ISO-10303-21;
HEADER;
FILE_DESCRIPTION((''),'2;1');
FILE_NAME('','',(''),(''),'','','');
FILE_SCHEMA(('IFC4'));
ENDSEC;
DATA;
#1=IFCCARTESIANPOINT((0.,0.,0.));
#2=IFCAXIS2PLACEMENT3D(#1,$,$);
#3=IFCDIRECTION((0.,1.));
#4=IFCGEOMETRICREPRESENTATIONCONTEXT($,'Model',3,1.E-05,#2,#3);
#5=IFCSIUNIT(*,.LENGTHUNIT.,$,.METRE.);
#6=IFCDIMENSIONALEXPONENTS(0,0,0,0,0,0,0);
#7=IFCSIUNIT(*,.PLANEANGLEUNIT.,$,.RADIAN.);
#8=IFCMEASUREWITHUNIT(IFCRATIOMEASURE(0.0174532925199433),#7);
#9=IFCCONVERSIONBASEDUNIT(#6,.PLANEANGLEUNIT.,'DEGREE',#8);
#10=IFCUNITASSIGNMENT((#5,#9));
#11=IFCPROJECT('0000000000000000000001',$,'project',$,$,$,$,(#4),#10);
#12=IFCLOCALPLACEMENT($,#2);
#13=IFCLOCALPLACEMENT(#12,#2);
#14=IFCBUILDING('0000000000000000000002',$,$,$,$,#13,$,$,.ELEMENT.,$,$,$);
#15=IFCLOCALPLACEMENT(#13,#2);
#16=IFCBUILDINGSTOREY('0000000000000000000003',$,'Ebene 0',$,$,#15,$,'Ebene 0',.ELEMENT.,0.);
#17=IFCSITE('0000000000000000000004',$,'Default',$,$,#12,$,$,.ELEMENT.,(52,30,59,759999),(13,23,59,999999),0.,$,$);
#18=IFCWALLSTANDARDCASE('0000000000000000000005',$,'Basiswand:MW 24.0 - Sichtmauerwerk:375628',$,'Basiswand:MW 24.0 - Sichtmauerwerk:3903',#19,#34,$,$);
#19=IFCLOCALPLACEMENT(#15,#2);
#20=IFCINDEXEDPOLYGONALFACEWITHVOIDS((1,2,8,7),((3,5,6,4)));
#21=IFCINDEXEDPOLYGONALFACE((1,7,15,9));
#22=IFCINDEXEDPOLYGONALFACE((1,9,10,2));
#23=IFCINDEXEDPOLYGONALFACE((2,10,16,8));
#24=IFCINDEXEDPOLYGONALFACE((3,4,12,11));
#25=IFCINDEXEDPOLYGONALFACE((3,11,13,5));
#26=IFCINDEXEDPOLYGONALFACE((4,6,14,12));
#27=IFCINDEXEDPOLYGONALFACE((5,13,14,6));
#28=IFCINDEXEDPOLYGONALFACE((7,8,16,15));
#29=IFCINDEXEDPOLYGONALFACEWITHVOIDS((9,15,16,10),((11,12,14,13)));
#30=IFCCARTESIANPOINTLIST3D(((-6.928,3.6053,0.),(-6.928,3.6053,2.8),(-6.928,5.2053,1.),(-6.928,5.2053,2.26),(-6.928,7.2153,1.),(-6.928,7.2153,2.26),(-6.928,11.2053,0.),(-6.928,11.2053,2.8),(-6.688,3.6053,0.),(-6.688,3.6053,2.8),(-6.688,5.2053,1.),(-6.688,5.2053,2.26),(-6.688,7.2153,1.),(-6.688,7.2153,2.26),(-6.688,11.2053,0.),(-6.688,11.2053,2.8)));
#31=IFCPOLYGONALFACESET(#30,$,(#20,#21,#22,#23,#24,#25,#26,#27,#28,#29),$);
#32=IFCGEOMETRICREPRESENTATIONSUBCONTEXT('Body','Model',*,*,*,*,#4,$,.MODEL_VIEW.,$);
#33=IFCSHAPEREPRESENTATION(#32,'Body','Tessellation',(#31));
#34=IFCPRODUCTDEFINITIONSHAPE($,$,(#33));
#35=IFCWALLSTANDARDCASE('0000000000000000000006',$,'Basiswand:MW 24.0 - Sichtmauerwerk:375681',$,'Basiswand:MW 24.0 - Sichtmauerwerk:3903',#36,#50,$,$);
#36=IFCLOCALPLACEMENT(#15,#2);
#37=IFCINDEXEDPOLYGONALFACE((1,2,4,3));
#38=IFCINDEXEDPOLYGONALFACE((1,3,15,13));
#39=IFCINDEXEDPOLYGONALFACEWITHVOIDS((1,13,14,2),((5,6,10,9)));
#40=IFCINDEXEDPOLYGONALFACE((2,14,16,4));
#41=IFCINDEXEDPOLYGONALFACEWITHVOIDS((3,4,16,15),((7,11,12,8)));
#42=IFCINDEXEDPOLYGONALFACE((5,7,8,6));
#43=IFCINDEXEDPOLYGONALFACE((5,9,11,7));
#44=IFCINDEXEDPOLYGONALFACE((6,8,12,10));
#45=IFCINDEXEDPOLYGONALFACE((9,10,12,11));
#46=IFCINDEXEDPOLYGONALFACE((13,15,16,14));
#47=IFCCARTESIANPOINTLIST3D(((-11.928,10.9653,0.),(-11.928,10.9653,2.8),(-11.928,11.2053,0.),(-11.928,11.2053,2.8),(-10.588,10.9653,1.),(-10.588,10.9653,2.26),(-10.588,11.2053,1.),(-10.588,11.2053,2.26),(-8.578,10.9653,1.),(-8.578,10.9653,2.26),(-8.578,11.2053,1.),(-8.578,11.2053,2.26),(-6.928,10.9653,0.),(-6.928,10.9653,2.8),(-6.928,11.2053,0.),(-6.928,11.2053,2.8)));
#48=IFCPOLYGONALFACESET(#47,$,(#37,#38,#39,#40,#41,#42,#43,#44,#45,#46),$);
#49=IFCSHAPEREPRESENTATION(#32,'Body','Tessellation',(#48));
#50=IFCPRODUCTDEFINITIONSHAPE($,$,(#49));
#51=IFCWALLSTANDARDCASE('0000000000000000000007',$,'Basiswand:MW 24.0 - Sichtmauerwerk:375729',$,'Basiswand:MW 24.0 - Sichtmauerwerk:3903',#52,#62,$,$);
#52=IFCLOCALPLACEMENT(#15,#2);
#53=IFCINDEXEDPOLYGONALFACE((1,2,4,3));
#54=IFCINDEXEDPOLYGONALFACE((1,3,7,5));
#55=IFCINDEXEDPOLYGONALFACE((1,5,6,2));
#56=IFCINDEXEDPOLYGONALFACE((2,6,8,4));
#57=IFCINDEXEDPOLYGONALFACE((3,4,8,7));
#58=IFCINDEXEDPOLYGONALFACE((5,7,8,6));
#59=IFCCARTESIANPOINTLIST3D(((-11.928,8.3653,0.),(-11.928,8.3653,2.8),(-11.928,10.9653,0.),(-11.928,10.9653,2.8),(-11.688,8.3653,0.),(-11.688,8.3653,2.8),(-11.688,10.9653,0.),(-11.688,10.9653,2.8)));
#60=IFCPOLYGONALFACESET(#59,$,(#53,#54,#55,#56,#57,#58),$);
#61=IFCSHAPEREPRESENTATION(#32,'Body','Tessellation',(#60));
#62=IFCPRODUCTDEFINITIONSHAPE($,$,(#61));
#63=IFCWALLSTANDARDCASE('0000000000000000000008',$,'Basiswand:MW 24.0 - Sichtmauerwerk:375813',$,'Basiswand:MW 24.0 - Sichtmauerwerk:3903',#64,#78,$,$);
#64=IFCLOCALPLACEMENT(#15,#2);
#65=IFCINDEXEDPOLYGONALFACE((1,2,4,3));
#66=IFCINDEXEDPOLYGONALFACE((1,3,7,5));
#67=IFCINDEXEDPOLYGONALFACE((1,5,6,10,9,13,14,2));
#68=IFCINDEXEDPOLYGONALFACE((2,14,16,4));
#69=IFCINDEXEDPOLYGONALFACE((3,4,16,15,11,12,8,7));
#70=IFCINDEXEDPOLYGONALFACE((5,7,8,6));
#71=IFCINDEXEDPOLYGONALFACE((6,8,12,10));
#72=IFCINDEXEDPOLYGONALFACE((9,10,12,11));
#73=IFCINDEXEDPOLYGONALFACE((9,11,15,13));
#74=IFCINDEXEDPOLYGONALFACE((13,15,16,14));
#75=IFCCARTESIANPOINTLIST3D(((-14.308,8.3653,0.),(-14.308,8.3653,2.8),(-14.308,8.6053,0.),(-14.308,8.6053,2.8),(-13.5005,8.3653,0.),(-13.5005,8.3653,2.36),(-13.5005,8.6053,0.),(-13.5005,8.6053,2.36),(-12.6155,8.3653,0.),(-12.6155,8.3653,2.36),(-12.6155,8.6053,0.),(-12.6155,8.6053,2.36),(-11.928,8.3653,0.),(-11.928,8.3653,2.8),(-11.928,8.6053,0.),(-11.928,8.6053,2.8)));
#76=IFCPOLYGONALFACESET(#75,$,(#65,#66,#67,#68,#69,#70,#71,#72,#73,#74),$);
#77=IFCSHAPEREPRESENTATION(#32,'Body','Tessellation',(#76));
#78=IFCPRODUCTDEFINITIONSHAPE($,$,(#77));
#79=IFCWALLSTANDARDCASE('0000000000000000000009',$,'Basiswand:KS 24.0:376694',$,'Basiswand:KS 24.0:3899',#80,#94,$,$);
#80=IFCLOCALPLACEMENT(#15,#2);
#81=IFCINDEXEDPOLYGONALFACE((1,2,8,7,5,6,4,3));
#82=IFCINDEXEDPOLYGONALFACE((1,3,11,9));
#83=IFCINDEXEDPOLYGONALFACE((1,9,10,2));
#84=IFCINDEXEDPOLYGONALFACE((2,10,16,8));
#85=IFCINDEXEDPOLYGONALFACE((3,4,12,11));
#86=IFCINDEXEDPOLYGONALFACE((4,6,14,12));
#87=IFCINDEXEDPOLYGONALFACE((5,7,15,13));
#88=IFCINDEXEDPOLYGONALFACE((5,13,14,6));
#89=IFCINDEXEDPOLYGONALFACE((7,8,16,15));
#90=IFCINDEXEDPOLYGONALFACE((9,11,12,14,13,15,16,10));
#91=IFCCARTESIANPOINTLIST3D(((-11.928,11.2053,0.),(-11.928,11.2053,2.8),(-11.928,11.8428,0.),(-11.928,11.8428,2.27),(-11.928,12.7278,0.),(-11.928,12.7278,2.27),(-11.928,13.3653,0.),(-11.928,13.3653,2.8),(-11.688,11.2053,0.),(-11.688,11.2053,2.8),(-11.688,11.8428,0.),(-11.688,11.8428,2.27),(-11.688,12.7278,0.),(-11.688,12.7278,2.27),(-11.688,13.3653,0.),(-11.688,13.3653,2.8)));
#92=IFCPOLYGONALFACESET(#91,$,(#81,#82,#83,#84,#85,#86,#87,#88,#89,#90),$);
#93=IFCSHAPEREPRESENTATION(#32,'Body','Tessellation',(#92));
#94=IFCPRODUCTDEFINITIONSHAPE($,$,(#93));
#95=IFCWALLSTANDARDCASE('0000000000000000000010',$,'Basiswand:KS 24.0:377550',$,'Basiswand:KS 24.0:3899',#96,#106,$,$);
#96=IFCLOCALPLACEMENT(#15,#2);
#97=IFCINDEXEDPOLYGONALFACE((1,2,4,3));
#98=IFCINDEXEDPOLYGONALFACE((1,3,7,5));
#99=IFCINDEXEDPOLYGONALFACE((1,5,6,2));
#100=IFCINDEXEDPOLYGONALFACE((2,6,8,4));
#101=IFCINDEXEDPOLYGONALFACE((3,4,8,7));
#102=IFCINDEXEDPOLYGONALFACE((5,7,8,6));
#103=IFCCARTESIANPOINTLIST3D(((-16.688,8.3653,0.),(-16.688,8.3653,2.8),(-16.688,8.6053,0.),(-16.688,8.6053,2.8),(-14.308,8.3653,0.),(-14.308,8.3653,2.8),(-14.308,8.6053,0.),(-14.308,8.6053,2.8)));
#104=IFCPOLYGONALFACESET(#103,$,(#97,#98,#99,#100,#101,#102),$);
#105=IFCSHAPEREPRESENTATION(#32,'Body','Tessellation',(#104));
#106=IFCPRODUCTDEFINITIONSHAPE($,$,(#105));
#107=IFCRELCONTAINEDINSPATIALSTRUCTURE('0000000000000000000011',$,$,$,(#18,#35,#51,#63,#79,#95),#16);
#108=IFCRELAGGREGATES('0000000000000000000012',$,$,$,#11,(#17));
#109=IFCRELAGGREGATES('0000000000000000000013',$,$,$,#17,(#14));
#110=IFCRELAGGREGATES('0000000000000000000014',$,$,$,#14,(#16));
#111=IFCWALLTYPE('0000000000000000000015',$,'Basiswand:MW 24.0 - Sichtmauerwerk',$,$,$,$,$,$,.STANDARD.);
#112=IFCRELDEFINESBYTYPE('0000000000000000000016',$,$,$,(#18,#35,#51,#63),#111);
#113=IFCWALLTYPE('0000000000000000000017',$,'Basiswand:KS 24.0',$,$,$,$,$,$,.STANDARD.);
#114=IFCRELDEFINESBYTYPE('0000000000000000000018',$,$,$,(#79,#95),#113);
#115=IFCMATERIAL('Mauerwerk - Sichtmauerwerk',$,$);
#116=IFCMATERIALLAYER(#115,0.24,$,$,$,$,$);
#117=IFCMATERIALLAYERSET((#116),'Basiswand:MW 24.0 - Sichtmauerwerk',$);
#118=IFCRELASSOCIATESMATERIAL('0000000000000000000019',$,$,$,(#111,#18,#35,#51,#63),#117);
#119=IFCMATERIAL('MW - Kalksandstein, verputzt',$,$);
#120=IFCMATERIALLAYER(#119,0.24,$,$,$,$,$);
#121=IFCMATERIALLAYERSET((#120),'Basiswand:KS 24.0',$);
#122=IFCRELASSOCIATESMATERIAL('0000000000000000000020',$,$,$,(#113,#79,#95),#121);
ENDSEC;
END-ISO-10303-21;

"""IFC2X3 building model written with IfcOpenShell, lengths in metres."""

from ifc_helpers import new_model, entity, si_unit, converted_unit, direction, frame, frame_2d, origin, place, context, subcontext, project, spatial, polyline, rectangle, extrude, clip, bounded_halfspace, material, layer, layer_set, layer_usage, type_object, element, save


model = new_model("IFC2X3")

# Units and contexts
model_context = context("Model", 3, precision=1e-05, world=origin(), true_north=direction((0.0, 1.0)))
body_context = subcontext(model_context, "Body", "Model", "MODEL_VIEW")
ifc_project = project(units=[si_unit("LENGTHUNIT", "METRE"), converted_unit("PLANEANGLEUNIT", "DEGREE", entity("IfcRatioMeasure", 0.0174532925199433), si_unit("PLANEANGLEUNIT", "RADIAN"), dimensions=[0, 0, 0, 0, 0, 0, 0])], contexts=[model_context])

# Site, building, storey
site_placement = place(None, origin())
site = spatial("IfcSite", under=ifc_project, at=site_placement, Name="Default", CompositionType="ELEMENT", RefLatitude=(52, 30, 59, 759999), RefLongitude=(13, 23, 59, 999999), RefElevation=0.0)
building_placement = place(site_placement, origin())
building = spatial("IfcBuilding", under=site, at=building_placement, CompositionType="ELEMENT")
storey_placement = place(building_placement, origin())
storey = spatial("IfcBuildingStorey", under=building, at=storey_placement, Name="Ebene 0", LongName="Ebene 0", CompositionType="ELEMENT", Elevation=0.0)

# Shared definitions
ifc_material_1 = material(Name="Mauerwerk - Sichtmauerwerk")
ifc_layer_1 = layer(ifc_material_1, 0.24)
ifc_layer_set_1 = layer_set([ifc_layer_1], Name="Basiswand:MW 24.0 - Sichtmauerwerk")
wall_type_1 = type_object("IfcWallType", Name="Basiswand:MW 24.0 - Sichtmauerwerk", PredefinedType="STANDARD", material=ifc_layer_set_1)

# Walls, openings
ifc_layer_usage_1 = layer_usage(ifc_layer_set_1, "AXIS2", "NEGATIVE", 0.12)
wall_1_placement = place(storey_placement, frame((-6.808, 3.6053, 0.0), z_axis=(0.0, 0.0, 1.0), x_axis=(0.0, 1.0, 0.0)))
wall_1 = element("IfcWallStandardCase", 1, at=wall_1_placement, inside=storey, type_object=wall_type_1, material=ifc_layer_usage_1, Name="Basiswand:MW 24.0 - Sichtmauerwerk:375628", ObjectType="Basiswand:MW 24.0 - Sichtmauerwerk:3903", context=body_context, shape_type="Clipping", body=[
    clip(clip(extrude(rectangle(XDim=7.6, YDim=0.24, at=frame_2d((3.8, 0.0), x_axis=(-1.0, 0.0))), origin(), (0.0, 0.0, 1.0), 2.8), bounded_halfspace(frame((0.0, -0.12, 2.8), z_axis=(0.0, 0.0, -1.0), x_axis=(0.0, 1.0, 0.0)), True, frame((0.0, -0.12, 2.8)), polyline([(0.0, 0.0), (5.0, 0.0), (5.0, 0.24), (0.0, 0.24), (0.0, 0.0)]))), bounded_halfspace(frame((5.005, -0.12, 2.8), z_axis=(0.0, 0.0, -1.0), x_axis=(1.0, 0.0, 0.0)), True, frame((5.005, -0.12, 2.8)), polyline([(0.0, 0.0), (2.595, 0.0), (2.595, 0.24), (2.355, 0.24), (0.0, 0.24), (0.0, 0.0)]))),
])
opening_1_placement = place(wall_1_placement, frame((1.6, -0.12, 1.0)))
element("IfcOpeningElement", 2, at=opening_1_placement, cuts=wall_1, ObjectType="Opening", context=body_context, shape_type="SweptSolid", body=[
    extrude(rectangle(XDim=1.26, YDim=2.01, at=frame_2d((0.63, 1.005), x_axis=(1.0, 0.0))), frame((0.0, 0.0, 0.0), z_axis=(0.0, 1.0, 0.0), x_axis=(0.0, 0.0, 1.0)), (0.0, 0.0, 1.0), 0.24),
])
ifc_layer_usage_2 = layer_usage(ifc_layer_set_1, "AXIS2", "NEGATIVE", 0.12)
wall_2_placement = place(storey_placement, frame((-6.928, 11.0853, 0.0), z_axis=(0.0, 0.0, 1.0), x_axis=(-1.0, 0.0, 0.0)))
wall_2 = element("IfcWallStandardCase", 3, at=wall_2_placement, inside=storey, type_object=wall_type_1, material=ifc_layer_usage_2, Name="Basiswand:MW 24.0 - Sichtmauerwerk:375681", ObjectType="Basiswand:MW 24.0 - Sichtmauerwerk:3903", context=body_context, shape_type="Clipping", body=[
    clip(extrude(rectangle(XDim=5.0, YDim=0.24, at=frame_2d((2.5, 0.0), x_axis=(-1.0, 0.0))), origin(), (0.0, 0.0, 1.0), 2.8), bounded_halfspace(frame((0.0, -0.12, 2.8), z_axis=(0.0, 0.0, -1.0), x_axis=(0.0, -1.0, 0.0)), True, frame((0.0, -0.12, 2.8)), polyline([(0.0, 0.0), (4.76, 0.0), (5.0, 0.0), (5.0, 0.24), (4.76, 0.24), (0.0, 0.24), (0.0, 0.0)]))),
])
opening_2_placement = place(wall_2_placement, frame((1.65, -0.12, 1.0)))
element("IfcOpeningElement", 4, at=opening_2_placement, cuts=wall_2, ObjectType="Opening", context=body_context, shape_type="SweptSolid", body=[
    extrude(rectangle(XDim=1.26, YDim=2.01, at=frame_2d((0.63, 1.005), x_axis=(1.0, 0.0))), frame((0.0, 0.0, 0.0), z_axis=(0.0, 1.0, 0.0), x_axis=(0.0, 0.0, 1.0)), (0.0, 0.0, 1.0), 0.24),
])

# Wall
ifc_layer_usage_3 = layer_usage(ifc_layer_set_1, "AXIS2", "NEGATIVE", 0.12)
wall_3_placement = place(storey_placement, frame((-11.808, 10.9653, 0.0), z_axis=(0.0, 0.0, 1.0), x_axis=(0.0, -1.0, 0.0)))
element("IfcWallStandardCase", 5, at=wall_3_placement, inside=storey, type_object=wall_type_1, material=ifc_layer_usage_3, Name="Basiswand:MW 24.0 - Sichtmauerwerk:375729", ObjectType="Basiswand:MW 24.0 - Sichtmauerwerk:3903", context=body_context, shape_type="Clipping", body=[
    clip(clip(extrude(rectangle(XDim=2.6, YDim=0.24, at=frame_2d((1.3, 0.0), x_axis=(-1.0, 0.0))), origin(), (0.0, 0.0, 1.0), 2.8), bounded_halfspace(frame((2.36, -0.12, 2.8), z_axis=(0.0, 0.0, -1.0), x_axis=(0.0, -1.0, 0.0)), True, frame((2.36, -0.12, 2.8)), polyline([(0.0, 0.0), (0.24, 0.0), (0.24, 0.24), (0.0, 0.24), (0.0, 0.0)]))), bounded_halfspace(frame((0.0, -0.12, 2.8), z_axis=(0.0, 0.0, -1.0), x_axis=(-1.0, 0.0, 0.0)), True, frame((0.0, -0.12, 2.8)), polyline([(0.0, 0.0), (2.355, 0.0), (2.355, 0.24), (0.0, 0.24), (0.0, 0.0)]))),
])

# Walls, openings
ifc_layer_usage_4 = layer_usage(ifc_layer_set_1, "AXIS2", "NEGATIVE", 0.12)
wall_4_placement = place(storey_placement, frame((-11.928, 8.4853, 0.0), z_axis=(0.0, 0.0, 1.0), x_axis=(-1.0, 0.0, 0.0)))
wall_4 = element("IfcWallStandardCase", 6, at=wall_4_placement, inside=storey, type_object=wall_type_1, material=ifc_layer_usage_4, Name="Basiswand:MW 24.0 - Sichtmauerwerk:375813", ObjectType="Basiswand:MW 24.0 - Sichtmauerwerk:3903", context=body_context, shape_type="Clipping", body=[
    clip(extrude(rectangle(XDim=2.38, YDim=0.24, at=frame_2d((1.19, 0.0), x_axis=(-1.0, 0.0))), origin(), (0.0, 0.0, 1.0), 2.8), bounded_halfspace(frame((0.0, -0.12, 2.8), z_axis=(0.0, 0.0, -1.0), x_axis=(1.0, 0.0, 0.0)), True, frame((0.0, -0.12, 2.8)), polyline([(0.0, 0.0), (2.38, 0.0), (2.38, 0.24), (0.0, 0.24), (0.0, 0.0)]))),
])
opening_3_placement = place(wall_4_placement, frame((1.5725, 0.12, 0.0)))
element("IfcOpeningElement", 7, at=opening_3_placement, cuts=wall_4, ObjectType="Opening", context=body_context, shape_type="SweptSolid", body=[
    extrude(rectangle(XDim=2.36, YDim=0.885, at=frame_2d((1.18, 0.4425), x_axis=(1.0, 0.0))), frame((0.0, 0.0, 0.0), z_axis=(0.0, -1.0, 0.0), x_axis=(0.0, 0.0, 1.0)), (0.0, 0.0, 1.0), 0.24),
])
ifc_material_2 = material(Name="MW - Kalksandstein, verputzt")
ifc_layer_2 = layer(ifc_material_2, 0.24)
ifc_layer_set_2 = layer_set([ifc_layer_2], Name="Basiswand:KS 24.0")
ifc_layer_usage_5 = layer_usage(ifc_layer_set_2, "AXIS2", "NEGATIVE", 0.12)
wall_type_2 = type_object("IfcWallType", Name="Basiswand:KS 24.0", PredefinedType="STANDARD", material=ifc_layer_set_2)
wall_5_placement = place(storey_placement, frame((-11.808, 13.3653, 0.0), z_axis=(0.0, 0.0, 1.0), x_axis=(0.0, -1.0, 0.0)))
wall_5 = element("IfcWallStandardCase", 8, at=wall_5_placement, inside=storey, type_object=wall_type_2, material=ifc_layer_usage_5, Name="Basiswand:KS 24.0:376694", ObjectType="Basiswand:KS 24.0:3899", context=body_context, shape_type="Clipping", body=[
    clip(extrude(rectangle(XDim=2.16, YDim=0.24, at=frame_2d((1.08, 0.0), x_axis=(-1.0, 0.0))), origin(), (0.0, 0.0, 1.0), 2.8), bounded_halfspace(frame((0.0, -0.12, 2.8), z_axis=(0.0, 0.0, -1.0), x_axis=(-1.0, 0.0, 0.0)), True, frame((0.0, -0.12, 2.8)), polyline([(0.0, 0.0), (2.16, 0.0), (2.16, 0.24), (0.0, 0.24), (0.0, 0.0)]))),
])
opening_4_placement = place(wall_5_placement, frame((1.5225, 0.12, 0.0)))
element("IfcOpeningElement", 9, at=opening_4_placement, cuts=wall_5, ObjectType="Opening", context=body_context, shape_type="SweptSolid", body=[
    extrude(rectangle(XDim=2.27, YDim=0.885, at=frame_2d((1.135, 0.4425), x_axis=(1.0, 0.0))), frame((0.0, 0.0, 0.0), z_axis=(0.0, -1.0, 0.0), x_axis=(0.0, 0.0, 1.0)), (0.0, 0.0, 1.0), 0.24),
])

# Wall
ifc_layer_usage_6 = layer_usage(ifc_layer_set_2, "AXIS2", "NEGATIVE", 0.12)
wall_6_placement = place(storey_placement, frame((-16.688, 8.4853, 0.0)))
element("IfcWallStandardCase", 10, at=wall_6_placement, inside=storey, type_object=wall_type_2, material=ifc_layer_usage_6, Name="Basiswand:KS 24.0:377550", ObjectType="Basiswand:KS 24.0:3899", context=body_context, shape_type="Clipping", body=[
    clip(extrude(rectangle(XDim=2.38, YDim=0.24, at=frame_2d((1.19, 0.0), x_axis=(-1.0, 0.0))), origin(), (0.0, 0.0, 1.0), 2.8), bounded_halfspace(frame((0.0, -0.12, 2.8), z_axis=(0.0, 0.0, -1.0), x_axis=(-1.0, 0.0, 0.0)), True, frame((0.0, -0.12, 2.8)), polyline([(0.0, 0.0), (2.38, 0.0), (2.38, 0.24), (0.0, 0.24), (0.0, 0.0)]))),
])

save(model, "model.ifc")
